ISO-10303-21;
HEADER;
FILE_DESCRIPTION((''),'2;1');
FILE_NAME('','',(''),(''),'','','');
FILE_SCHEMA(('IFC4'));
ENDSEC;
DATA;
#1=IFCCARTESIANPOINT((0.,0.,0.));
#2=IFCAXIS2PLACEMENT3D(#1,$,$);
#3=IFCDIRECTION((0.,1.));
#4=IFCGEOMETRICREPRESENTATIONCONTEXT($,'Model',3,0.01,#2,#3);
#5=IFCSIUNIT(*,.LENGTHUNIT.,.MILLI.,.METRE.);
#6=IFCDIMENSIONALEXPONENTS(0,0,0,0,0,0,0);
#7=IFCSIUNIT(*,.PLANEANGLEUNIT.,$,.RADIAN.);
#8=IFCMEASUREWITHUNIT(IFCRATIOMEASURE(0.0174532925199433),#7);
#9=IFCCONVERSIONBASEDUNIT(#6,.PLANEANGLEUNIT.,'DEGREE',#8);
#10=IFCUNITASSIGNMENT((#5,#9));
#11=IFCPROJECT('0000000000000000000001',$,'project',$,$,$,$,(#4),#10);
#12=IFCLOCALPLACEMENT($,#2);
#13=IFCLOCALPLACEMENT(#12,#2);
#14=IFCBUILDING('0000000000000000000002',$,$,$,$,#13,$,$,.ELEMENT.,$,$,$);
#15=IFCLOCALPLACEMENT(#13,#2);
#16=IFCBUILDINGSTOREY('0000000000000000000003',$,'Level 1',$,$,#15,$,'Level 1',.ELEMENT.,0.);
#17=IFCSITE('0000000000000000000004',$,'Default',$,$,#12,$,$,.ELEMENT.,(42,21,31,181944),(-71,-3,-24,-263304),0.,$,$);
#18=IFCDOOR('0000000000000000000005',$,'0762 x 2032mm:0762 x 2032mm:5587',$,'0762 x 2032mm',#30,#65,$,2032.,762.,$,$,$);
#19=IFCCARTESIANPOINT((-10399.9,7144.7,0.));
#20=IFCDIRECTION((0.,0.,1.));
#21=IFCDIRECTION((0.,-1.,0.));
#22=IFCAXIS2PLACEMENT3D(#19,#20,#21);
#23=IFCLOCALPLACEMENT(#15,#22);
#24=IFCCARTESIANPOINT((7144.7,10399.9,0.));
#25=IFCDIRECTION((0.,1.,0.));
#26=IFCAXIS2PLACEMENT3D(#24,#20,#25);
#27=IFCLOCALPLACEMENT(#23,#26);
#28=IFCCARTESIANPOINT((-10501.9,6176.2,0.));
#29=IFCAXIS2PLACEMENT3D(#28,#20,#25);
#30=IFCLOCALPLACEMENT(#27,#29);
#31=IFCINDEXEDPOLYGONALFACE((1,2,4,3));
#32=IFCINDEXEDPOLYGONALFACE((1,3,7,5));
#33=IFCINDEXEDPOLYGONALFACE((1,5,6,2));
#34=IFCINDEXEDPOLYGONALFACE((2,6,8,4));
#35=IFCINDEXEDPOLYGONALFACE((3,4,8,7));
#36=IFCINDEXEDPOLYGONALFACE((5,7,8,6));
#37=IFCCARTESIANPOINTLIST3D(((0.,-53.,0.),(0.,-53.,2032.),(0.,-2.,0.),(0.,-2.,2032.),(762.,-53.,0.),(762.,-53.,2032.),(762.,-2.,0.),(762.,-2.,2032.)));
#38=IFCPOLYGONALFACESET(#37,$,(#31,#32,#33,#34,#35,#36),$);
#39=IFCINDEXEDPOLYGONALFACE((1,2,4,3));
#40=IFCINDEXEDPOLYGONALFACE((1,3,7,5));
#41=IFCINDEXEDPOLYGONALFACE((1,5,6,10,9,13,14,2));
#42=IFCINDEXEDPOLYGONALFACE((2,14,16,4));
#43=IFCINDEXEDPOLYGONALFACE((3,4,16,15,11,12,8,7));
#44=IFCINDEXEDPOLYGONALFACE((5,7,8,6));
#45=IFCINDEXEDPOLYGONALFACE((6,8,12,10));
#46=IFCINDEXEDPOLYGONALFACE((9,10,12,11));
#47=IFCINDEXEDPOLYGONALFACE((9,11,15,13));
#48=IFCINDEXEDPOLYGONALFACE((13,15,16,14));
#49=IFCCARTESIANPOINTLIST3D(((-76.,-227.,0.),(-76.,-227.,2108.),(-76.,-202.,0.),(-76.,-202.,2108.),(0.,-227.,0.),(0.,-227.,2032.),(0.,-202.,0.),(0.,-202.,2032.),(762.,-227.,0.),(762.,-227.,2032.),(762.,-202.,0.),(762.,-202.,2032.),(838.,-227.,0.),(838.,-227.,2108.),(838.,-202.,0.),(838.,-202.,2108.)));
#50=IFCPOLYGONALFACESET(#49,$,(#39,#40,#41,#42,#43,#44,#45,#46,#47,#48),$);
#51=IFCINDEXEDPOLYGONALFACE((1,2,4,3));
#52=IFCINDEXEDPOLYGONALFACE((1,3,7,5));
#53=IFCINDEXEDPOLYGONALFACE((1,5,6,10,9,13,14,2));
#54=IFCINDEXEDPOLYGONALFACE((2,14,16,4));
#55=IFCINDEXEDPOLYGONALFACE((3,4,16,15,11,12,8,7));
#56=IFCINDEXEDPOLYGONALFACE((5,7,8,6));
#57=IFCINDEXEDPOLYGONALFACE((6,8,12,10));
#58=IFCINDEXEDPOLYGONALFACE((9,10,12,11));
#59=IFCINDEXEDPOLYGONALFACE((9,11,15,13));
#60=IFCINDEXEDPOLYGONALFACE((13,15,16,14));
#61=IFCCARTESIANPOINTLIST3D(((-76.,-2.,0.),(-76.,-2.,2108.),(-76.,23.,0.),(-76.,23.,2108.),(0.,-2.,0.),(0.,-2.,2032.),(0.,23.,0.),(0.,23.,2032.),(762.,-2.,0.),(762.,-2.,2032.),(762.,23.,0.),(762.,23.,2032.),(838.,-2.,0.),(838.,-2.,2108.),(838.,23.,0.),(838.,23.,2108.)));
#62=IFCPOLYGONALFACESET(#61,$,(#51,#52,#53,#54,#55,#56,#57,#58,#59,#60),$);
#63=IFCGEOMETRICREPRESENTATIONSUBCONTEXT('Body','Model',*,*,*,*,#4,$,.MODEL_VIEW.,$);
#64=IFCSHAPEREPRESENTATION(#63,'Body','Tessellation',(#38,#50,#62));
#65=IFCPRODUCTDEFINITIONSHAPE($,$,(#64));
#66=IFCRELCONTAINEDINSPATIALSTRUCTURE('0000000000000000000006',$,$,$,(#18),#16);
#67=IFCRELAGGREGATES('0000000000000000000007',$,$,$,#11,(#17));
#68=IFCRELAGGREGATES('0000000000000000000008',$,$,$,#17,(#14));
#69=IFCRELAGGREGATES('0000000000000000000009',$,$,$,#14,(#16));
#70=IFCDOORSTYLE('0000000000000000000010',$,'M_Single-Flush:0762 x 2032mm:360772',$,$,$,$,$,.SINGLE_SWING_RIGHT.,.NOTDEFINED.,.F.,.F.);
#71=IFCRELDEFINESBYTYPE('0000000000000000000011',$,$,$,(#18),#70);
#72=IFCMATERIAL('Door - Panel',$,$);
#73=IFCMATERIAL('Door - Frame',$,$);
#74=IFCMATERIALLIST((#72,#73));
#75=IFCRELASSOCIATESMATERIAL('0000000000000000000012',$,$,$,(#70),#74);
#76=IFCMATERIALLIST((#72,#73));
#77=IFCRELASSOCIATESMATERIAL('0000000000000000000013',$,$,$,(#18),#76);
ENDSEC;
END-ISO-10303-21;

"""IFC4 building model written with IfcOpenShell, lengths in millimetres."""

from ifc_helpers import new_model, entity, si_unit, converted_unit, direction, frame, frame_2d, origin, place, context, subcontext, project, spatial, polyline, rectangle, outline, extrude, source, transform, mapped, material, material_list, type_object, type_shapes, element, save


model = new_model("IFC4")

# Units and contexts
model_context = context("Model", 3, precision=0.01, world=origin(), true_north=direction((0.0, 1.0)))
body_context = subcontext(model_context, "Body", "Model", "MODEL_VIEW")
ifc_project = project(units=[si_unit("LENGTHUNIT", "METRE", prefix="MILLI"), converted_unit("PLANEANGLEUNIT", "DEGREE", entity("IfcRatioMeasure", 0.0174532925199433), si_unit("PLANEANGLEUNIT", "RADIAN"), dimensions=[0, 0, 0, 0, 0, 0, 0])], contexts=[model_context])

# Site, building, storey
site_placement = place(None, origin())
site = spatial("IfcSite", under=ifc_project, at=site_placement, Name="Default", CompositionType="ELEMENT", RefLatitude=(42, 21, 31, 181944), RefLongitude=(-71, -3, -24, -263304), RefElevation=0.0)
building_placement = place(site_placement, origin())
building = spatial("IfcBuilding", under=site, at=building_placement, CompositionType="ELEMENT")
storey_placement = place(building_placement, origin())
storey = spatial("IfcBuildingStorey", under=building, at=storey_placement, Name="Level 1", LongName="Level 1", CompositionType="ELEMENT", Elevation=0.0)

# Shared definitions
placement_1 = place(storey_placement, frame((-10399.9, 7144.7, 0.0), z_axis=(0.0, 0.0, 1.0), x_axis=(0.0, -1.0, 0.0)))

# Door
ifc_material_1 = material(Name="Door - Panel")
ifc_material_2 = material(Name="Door - Frame")
ifc_material_list_1 = material_list([ifc_material_1, ifc_material_2])
ifc_material_list_2 = material_list([ifc_material_1, ifc_material_2])
door_style = type_object("IfcDoorStyle", Name="M_Single-Flush:0762 x 2032mm:360772", ConstructionType="NOTDEFINED", OperationType="SINGLE_SWING_RIGHT", ParameterTakesPrecedence=False, Sizeable=False, material=ifc_material_list_2)
shared_shape = source(origin(), body_context, "Body", "SweptSolid", [
    extrude(rectangle(XDim=762.0, YDim=51.0, at=frame_2d((0.0, 0.0), x_axis=(1.0, 0.0))), frame((381.0, -27.5, 0.0), z_axis=(0.0, 0.0, 1.0), x_axis=(-1.0, 0.0, 0.0)), (0.0, 0.0, 1.0), 2032.0),
    extrude(outline(polyline([(-457.0, -1035.0), (-381.0, -1035.0), (-381.0, 997.0), (381.0, 997.0), (381.0, -1035.0), (457.0, -1035.0), (457.0, 1073.0), (-457.0, 1073.0), (-457.0, -1035.0)])), frame((381.0, -227.0, 1035.0), z_axis=(0.0, 1.0, 0.0), x_axis=(-1.0, 0.0, 0.0)), (0.0, 0.0, 1.0), 25.0),
    extrude(outline(polyline([(-1073.0, -457.0), (1035.0, -457.0), (1035.0, -381.0), (-997.0, -381.0), (-997.0, 381.0), (1035.0, 381.0), (1035.0, 457.0), (-1073.0, 457.0), (-1073.0, -457.0)])), frame((381.0, -2.0, 1035.0), z_axis=(0.0, 1.0, 0.0), x_axis=(0.0, 0.0, -1.0)), (0.0, 0.0, 1.0), 25.0),
])
type_shapes(door_style, [shared_shape])
placement_2 = place(placement_1, frame((7144.7, 10399.9, 0.0), z_axis=(0.0, 0.0, 1.0), x_axis=(0.0, 1.0, 0.0)))
door_placement = place(placement_2, frame((-10501.9, 6176.2, 0.0), z_axis=(0.0, 0.0, 1.0), x_axis=(0.0, 1.0, 0.0)))
element("IfcDoor", 1, at=door_placement, inside=storey, type_object=door_style, material=ifc_material_list_1, Name="0762 x 2032mm:0762 x 2032mm:5587", ObjectType="0762 x 2032mm", OverallHeight=2032.0, OverallWidth=762.0, context=body_context, shape_type="MappedRepresentation", body=[
    mapped(shared_shape, transform((0.0, 0.0, 0.0), scale=1.0)),
])

save(model, "model.ifc")
